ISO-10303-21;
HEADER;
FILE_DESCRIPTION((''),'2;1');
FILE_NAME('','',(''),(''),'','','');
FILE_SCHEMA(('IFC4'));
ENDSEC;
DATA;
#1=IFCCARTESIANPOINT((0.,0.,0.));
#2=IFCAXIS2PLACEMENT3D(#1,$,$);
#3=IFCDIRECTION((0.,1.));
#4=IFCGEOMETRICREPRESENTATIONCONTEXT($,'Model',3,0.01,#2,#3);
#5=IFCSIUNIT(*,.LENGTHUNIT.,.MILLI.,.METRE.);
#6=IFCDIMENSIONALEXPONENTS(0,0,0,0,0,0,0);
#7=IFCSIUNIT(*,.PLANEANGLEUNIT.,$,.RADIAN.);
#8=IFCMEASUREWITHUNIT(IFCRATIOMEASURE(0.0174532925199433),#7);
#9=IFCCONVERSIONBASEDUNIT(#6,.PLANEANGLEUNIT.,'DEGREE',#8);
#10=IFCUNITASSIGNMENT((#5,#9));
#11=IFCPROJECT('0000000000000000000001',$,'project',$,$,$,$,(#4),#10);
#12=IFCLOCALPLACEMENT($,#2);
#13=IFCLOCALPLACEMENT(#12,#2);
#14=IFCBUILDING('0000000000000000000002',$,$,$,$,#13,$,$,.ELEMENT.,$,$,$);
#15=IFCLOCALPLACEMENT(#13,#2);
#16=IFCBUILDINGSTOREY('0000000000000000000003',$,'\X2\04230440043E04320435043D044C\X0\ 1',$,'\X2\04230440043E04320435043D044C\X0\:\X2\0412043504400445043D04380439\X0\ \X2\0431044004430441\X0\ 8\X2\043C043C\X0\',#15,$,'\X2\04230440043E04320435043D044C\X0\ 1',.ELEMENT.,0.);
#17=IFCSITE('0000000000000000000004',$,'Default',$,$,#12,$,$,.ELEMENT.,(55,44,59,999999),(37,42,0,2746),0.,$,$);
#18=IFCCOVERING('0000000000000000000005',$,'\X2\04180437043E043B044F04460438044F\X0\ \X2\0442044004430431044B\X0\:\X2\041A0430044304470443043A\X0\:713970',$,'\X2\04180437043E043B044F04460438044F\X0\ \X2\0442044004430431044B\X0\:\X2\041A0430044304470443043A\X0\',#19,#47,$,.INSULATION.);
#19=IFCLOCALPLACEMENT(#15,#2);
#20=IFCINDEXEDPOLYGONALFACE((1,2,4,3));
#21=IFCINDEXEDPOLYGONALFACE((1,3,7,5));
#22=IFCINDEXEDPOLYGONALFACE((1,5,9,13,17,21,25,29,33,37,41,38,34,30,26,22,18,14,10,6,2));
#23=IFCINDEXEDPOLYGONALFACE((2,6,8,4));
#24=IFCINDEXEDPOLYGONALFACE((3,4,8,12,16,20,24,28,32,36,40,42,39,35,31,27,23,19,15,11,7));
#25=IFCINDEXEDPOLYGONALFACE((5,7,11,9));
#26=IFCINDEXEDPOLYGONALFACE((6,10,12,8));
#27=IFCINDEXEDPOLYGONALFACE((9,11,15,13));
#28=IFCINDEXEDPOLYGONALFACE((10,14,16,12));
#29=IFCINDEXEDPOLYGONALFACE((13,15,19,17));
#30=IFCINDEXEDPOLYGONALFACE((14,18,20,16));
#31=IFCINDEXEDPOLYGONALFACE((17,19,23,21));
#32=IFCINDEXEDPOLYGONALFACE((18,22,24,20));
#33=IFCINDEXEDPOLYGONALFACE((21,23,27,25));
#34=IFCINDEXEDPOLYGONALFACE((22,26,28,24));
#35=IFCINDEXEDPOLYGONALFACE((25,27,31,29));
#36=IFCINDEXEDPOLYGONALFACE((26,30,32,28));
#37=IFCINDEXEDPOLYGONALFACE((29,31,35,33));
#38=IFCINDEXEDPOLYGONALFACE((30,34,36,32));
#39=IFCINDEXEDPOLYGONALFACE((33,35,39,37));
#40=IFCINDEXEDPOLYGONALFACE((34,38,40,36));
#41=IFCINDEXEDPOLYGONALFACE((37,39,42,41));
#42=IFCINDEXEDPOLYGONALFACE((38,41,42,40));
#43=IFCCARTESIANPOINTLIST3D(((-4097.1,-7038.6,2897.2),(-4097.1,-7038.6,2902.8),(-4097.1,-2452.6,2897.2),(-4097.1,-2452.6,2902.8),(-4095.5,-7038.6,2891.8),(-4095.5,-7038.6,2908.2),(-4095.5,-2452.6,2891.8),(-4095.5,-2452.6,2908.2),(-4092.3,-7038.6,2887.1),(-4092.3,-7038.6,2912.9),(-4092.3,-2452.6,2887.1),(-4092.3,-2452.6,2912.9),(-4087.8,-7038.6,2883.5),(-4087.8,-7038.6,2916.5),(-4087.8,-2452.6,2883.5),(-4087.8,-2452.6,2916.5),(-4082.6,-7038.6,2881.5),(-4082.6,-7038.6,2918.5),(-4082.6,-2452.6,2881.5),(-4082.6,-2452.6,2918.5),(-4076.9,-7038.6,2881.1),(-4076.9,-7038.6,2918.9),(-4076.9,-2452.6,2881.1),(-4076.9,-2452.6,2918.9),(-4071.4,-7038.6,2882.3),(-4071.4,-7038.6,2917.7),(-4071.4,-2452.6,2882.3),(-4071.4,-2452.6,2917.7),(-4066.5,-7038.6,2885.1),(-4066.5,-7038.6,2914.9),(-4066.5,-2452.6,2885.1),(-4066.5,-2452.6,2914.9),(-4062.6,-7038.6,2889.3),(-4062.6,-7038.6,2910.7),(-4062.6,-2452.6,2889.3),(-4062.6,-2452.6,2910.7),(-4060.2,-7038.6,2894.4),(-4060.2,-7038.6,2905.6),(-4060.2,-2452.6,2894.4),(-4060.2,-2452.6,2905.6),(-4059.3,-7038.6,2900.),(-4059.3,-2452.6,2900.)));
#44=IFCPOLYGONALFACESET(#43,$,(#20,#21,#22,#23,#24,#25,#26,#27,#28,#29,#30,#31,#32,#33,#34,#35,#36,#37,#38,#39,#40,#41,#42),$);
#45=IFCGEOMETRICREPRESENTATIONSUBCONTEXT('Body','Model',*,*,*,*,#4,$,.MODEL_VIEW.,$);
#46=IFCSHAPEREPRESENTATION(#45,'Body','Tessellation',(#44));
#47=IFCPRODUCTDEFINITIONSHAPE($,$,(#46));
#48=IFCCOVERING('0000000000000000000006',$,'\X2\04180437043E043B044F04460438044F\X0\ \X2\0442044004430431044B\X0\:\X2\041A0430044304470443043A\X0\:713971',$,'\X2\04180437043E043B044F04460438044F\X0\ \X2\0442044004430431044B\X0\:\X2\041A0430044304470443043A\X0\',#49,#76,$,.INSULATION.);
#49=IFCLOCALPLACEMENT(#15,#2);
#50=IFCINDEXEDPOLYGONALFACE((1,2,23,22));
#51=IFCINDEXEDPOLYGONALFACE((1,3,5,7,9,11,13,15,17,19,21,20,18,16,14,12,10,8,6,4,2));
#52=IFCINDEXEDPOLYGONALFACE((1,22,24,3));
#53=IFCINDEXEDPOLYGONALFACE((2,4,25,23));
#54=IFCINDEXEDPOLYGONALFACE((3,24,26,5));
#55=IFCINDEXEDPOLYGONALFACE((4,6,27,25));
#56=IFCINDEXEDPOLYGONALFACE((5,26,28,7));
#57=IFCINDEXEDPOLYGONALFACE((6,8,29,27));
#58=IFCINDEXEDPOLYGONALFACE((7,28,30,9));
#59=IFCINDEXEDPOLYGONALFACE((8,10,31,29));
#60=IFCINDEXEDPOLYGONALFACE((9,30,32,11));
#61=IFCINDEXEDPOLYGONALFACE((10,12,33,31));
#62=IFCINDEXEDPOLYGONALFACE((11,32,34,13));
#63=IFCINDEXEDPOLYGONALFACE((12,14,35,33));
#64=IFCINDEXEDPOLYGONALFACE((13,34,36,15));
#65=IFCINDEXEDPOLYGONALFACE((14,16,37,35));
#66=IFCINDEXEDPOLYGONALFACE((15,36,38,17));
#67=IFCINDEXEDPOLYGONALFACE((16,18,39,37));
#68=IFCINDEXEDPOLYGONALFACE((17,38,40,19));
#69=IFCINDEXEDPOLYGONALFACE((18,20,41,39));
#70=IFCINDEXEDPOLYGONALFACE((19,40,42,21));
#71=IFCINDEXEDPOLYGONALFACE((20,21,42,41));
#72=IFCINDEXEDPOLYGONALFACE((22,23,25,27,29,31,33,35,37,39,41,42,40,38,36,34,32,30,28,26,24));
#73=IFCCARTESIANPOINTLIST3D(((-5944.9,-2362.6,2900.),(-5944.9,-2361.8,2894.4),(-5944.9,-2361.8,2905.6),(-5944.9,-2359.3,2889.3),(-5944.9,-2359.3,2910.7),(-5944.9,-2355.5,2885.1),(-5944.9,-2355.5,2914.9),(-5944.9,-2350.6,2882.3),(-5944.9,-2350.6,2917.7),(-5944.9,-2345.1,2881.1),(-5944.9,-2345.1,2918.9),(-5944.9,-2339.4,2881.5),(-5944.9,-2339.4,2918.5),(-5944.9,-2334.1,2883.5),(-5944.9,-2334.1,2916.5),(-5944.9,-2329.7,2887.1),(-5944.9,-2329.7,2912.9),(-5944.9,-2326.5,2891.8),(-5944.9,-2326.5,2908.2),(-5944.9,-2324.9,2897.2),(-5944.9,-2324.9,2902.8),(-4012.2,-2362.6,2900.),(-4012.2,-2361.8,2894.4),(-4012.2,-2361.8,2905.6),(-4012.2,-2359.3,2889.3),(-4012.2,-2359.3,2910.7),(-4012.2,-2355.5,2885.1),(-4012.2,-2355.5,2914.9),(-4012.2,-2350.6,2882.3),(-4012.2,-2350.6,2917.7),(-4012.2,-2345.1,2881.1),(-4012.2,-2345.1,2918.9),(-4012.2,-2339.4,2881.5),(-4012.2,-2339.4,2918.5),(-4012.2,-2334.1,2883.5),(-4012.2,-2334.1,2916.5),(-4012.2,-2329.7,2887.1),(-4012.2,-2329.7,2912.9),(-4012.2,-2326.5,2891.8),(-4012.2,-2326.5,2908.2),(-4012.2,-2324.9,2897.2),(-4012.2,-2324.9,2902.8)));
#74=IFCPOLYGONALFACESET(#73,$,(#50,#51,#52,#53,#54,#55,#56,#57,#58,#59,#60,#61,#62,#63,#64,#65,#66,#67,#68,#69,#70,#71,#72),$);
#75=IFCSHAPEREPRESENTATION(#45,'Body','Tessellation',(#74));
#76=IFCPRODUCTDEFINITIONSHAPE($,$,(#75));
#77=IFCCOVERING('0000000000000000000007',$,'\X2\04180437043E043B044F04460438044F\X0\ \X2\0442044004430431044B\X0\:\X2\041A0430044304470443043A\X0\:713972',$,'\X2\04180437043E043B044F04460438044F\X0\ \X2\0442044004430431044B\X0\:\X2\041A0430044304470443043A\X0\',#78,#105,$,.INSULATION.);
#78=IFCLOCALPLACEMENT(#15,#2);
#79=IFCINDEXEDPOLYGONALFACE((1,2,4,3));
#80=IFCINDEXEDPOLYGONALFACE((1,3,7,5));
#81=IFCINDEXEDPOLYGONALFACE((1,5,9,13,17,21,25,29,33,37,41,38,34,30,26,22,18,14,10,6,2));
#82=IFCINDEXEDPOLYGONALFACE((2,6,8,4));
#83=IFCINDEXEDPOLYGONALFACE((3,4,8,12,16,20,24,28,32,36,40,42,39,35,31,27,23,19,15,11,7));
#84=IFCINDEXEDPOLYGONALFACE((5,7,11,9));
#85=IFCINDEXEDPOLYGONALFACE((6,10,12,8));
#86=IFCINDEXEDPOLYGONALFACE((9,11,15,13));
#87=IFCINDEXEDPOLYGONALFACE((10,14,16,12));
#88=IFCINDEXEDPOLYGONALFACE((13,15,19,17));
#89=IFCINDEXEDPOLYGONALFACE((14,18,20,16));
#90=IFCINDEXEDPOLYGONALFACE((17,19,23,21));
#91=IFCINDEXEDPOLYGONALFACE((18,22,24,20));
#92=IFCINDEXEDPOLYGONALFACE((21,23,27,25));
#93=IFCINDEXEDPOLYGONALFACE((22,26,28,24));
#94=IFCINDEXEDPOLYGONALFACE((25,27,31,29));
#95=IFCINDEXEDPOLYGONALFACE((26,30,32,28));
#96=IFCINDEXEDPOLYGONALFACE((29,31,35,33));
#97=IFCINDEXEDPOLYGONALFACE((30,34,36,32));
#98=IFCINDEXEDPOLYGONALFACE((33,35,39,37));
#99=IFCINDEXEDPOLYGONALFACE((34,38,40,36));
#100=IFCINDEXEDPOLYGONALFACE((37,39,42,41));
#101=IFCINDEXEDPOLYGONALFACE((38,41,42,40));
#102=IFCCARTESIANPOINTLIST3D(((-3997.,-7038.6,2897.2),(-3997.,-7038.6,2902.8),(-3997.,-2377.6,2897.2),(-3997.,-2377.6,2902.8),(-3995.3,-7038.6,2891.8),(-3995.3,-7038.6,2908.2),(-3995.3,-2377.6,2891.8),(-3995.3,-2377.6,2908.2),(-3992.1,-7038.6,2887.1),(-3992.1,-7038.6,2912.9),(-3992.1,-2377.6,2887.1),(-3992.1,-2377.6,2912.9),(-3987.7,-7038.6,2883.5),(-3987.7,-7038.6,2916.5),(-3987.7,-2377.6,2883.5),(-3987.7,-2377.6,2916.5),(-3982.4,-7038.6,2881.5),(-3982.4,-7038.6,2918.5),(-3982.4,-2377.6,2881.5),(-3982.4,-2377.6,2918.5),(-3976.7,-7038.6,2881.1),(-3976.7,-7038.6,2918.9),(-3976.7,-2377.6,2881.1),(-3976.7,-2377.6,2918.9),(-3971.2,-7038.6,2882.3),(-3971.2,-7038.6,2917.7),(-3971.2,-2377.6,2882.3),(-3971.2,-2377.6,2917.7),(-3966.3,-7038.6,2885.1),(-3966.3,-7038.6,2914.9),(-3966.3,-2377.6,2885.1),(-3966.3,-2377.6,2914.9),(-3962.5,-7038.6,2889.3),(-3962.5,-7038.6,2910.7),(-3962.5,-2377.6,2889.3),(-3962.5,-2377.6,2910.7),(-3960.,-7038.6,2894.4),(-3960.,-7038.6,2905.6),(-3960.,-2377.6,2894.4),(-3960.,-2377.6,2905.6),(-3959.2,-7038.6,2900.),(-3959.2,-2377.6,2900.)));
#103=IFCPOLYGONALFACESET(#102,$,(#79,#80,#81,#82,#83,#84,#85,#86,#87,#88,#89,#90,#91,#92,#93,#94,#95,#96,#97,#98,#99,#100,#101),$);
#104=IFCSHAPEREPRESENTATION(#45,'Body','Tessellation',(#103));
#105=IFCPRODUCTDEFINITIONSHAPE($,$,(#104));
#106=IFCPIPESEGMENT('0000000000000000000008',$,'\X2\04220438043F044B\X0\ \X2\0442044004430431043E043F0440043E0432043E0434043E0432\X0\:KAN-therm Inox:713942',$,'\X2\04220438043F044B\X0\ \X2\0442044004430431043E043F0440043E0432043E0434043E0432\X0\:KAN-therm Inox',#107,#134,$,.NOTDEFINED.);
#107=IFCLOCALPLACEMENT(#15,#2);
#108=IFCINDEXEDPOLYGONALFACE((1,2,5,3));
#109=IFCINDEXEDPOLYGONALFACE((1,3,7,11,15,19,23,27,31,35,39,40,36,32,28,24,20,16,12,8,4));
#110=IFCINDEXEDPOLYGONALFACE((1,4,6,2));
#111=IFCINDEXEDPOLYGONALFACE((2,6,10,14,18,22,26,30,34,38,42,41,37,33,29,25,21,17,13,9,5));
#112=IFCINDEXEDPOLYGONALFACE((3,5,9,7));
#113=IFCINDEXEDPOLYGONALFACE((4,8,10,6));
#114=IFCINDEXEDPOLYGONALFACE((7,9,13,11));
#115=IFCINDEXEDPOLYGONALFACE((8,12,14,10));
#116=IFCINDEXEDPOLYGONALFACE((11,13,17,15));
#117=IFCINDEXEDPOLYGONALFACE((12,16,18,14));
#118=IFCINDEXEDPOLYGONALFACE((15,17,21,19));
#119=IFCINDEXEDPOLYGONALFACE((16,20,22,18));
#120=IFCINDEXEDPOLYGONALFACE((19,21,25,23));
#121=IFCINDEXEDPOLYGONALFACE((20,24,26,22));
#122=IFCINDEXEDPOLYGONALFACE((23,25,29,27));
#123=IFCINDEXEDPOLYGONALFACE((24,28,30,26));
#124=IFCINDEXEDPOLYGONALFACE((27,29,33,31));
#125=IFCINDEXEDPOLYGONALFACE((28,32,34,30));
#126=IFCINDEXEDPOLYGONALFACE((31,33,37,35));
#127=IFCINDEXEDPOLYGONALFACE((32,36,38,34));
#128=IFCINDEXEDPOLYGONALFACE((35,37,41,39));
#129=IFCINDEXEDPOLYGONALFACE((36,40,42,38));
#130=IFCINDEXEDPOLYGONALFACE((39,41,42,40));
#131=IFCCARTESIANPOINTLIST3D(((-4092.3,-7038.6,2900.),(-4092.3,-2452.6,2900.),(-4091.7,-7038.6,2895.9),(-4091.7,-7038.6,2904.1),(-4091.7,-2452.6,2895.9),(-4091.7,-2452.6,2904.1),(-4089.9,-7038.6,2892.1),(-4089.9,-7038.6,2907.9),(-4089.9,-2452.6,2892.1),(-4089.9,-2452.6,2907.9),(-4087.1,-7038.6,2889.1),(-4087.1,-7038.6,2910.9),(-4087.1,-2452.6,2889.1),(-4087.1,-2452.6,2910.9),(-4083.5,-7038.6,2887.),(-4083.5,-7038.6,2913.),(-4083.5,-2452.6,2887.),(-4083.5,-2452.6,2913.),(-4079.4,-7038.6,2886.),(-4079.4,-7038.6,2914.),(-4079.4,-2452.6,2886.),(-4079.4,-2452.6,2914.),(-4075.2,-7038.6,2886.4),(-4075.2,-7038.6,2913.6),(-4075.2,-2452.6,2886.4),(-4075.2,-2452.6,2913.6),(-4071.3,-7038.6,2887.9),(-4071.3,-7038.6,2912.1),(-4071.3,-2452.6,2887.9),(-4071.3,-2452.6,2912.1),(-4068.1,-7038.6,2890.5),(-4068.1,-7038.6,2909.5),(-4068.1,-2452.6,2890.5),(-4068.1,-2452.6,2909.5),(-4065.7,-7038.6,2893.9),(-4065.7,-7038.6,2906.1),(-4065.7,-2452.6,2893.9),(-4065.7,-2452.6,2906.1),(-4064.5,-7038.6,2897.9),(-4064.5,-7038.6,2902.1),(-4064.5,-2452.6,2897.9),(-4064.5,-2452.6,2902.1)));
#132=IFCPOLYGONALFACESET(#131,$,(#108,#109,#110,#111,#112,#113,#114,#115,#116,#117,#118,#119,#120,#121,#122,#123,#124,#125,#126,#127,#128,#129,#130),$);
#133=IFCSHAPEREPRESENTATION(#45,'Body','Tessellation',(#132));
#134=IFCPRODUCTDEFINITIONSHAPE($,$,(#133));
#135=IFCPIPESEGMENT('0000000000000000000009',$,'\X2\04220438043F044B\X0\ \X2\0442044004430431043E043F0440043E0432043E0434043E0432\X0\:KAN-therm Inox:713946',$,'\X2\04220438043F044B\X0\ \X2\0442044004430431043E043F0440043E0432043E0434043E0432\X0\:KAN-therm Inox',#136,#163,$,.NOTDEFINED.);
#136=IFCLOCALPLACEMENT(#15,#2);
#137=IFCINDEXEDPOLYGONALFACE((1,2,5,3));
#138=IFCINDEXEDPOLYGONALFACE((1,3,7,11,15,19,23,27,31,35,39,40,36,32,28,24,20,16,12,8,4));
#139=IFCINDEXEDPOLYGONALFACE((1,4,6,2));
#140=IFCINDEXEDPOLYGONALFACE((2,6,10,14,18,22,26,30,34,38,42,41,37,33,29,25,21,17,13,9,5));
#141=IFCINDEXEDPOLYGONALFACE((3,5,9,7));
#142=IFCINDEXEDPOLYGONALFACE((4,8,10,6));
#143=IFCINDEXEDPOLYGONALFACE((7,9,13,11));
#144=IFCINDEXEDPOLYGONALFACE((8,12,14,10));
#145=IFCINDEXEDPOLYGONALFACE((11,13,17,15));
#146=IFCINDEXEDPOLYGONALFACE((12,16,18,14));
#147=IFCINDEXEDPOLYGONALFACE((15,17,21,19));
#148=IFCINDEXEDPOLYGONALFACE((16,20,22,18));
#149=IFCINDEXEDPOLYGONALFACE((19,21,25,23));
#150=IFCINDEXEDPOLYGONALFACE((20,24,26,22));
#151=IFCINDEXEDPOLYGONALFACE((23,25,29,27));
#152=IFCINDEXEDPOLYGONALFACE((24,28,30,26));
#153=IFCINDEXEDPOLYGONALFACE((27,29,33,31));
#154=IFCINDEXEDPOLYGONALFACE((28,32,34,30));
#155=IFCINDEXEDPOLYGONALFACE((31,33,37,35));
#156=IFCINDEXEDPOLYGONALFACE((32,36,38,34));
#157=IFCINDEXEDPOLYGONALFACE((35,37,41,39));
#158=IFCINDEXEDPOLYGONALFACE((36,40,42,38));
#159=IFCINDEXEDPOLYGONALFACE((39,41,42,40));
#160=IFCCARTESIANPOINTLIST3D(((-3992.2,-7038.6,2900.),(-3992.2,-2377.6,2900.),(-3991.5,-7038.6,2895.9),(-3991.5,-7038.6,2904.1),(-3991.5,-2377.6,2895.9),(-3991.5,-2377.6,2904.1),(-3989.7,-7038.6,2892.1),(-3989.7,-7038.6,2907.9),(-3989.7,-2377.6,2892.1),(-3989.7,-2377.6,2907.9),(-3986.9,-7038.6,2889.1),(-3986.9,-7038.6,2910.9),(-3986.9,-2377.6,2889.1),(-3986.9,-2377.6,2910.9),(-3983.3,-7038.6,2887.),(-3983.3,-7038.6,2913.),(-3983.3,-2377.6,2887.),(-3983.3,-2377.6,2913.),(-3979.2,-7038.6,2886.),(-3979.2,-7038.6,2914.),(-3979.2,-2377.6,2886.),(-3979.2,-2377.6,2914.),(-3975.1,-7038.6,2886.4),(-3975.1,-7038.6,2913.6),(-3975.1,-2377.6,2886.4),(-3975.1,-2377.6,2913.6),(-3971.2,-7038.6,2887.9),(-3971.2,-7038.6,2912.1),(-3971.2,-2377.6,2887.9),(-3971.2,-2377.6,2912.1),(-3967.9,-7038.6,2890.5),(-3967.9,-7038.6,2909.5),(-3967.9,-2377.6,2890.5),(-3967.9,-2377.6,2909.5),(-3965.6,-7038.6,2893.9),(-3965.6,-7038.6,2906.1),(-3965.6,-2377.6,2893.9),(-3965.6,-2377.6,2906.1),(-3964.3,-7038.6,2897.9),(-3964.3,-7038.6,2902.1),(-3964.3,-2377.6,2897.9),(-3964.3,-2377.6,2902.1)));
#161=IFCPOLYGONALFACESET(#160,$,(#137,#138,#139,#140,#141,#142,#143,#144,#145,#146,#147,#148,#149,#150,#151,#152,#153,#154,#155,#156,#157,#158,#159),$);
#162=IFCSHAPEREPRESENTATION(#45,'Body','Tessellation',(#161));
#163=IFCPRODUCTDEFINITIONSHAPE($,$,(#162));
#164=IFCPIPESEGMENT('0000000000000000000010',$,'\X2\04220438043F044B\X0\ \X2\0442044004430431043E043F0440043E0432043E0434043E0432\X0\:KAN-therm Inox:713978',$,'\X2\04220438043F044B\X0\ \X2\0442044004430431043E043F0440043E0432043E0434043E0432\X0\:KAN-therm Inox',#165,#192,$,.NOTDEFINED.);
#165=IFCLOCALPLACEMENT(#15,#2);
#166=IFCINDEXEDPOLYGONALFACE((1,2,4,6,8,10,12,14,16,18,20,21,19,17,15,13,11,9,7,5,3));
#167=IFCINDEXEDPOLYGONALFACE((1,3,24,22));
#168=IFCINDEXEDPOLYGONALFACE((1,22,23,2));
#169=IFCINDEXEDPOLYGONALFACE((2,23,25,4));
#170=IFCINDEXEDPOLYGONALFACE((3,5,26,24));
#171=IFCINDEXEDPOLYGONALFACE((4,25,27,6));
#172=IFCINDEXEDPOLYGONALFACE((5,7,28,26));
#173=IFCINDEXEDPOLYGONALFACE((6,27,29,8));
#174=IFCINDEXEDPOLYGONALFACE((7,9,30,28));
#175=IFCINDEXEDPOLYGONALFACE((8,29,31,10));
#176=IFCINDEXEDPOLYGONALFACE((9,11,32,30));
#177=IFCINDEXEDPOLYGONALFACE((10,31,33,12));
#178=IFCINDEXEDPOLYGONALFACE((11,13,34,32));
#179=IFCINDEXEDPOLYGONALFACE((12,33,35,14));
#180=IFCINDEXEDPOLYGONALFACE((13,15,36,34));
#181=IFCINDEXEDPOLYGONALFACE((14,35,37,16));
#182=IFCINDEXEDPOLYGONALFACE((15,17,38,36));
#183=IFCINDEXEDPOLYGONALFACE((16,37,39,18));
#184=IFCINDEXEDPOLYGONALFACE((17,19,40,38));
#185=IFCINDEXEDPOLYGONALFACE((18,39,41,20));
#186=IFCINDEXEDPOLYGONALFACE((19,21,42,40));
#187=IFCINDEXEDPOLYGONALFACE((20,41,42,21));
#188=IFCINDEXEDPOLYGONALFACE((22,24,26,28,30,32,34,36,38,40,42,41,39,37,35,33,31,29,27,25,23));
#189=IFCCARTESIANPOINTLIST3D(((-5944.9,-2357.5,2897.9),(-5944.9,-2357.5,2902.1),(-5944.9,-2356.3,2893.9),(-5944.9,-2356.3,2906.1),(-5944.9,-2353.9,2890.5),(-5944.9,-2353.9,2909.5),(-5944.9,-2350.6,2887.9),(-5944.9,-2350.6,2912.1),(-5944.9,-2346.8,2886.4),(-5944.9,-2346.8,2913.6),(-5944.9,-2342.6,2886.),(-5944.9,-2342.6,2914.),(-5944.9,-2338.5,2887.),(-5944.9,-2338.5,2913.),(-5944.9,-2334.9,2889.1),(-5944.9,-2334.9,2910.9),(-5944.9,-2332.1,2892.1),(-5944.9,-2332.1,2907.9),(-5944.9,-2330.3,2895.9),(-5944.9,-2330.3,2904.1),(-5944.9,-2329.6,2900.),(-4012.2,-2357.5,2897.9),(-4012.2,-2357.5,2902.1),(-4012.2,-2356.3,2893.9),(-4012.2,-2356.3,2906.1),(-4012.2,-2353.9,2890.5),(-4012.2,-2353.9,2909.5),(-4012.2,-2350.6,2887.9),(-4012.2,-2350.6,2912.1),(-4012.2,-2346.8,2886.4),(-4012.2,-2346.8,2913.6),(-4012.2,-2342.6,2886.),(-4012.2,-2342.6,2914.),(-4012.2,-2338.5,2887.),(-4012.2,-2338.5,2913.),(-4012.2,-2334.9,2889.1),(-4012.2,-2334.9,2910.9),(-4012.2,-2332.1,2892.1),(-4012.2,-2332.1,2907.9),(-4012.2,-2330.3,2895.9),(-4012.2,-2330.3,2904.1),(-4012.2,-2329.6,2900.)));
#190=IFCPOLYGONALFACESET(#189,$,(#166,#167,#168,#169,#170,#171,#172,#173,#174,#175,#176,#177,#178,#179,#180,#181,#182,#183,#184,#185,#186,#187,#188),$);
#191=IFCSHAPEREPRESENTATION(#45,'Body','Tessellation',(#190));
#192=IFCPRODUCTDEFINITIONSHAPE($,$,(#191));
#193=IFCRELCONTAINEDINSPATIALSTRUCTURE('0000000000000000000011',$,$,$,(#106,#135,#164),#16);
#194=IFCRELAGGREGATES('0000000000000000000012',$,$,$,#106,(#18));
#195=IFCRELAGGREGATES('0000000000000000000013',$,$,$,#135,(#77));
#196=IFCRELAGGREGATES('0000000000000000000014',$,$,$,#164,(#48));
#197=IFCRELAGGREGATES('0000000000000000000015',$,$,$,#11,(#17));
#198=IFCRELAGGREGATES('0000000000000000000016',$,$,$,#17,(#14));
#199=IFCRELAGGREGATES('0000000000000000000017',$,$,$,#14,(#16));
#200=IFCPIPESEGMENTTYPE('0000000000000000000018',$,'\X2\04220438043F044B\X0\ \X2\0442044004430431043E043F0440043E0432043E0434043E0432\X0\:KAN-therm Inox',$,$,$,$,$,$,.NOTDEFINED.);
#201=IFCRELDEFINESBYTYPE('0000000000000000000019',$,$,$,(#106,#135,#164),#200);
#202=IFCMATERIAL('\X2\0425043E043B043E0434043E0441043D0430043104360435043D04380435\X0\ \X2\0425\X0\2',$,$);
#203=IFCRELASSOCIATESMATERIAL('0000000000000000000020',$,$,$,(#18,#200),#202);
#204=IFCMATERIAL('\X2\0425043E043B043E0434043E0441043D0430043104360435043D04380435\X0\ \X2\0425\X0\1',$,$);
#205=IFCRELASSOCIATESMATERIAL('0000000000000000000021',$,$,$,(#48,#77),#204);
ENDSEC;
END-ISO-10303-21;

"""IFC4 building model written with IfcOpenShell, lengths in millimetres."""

from ifc_helpers import new_model, entity, si_unit, converted_unit, direction, frame, frame_2d, origin, origin_2d_with_axis, place, context, subcontext, project, spatial, circle, extrude, material, type_object, element, aggregate, save


model = new_model("IFC4")

# Units and contexts
model_context = context("Model", 3, precision=0.01, world=origin(), true_north=direction((0.0, 1.0)))
body_context = subcontext(model_context, "Body", "Model", "MODEL_VIEW")
ifc_project = project(units=[si_unit("LENGTHUNIT", "METRE", prefix="MILLI"), converted_unit("PLANEANGLEUNIT", "DEGREE", entity("IfcRatioMeasure", 0.0174532925199433), si_unit("PLANEANGLEUNIT", "RADIAN"), dimensions=[0, 0, 0, 0, 0, 0, 0])], contexts=[model_context])

# Site, building, storey
site_placement = place(None, origin())
site = spatial("IfcSite", under=ifc_project, at=site_placement, Name="Default", CompositionType="ELEMENT", RefLatitude=(55, 44, 59, 999999), RefLongitude=(37, 42, 0, 2746), RefElevation=0.0)
building_placement = place(site_placement, origin())
building = spatial("IfcBuilding", under=site, at=building_placement, CompositionType="ELEMENT")
storey_placement = place(building_placement, origin())
storey = spatial("IfcBuildingStorey", under=building, at=storey_placement, Name="Уровень 1", ObjectType="Уровень:Верхний брус 8мм", LongName="Уровень 1", CompositionType="ELEMENT", Elevation=0.0)

# Coverings
ifc_material_1 = material(Name="Холодоснабжение Х2")
covering_1_placement = place(storey_placement, frame((-4098.9, -7038.6, 2879.4)))
covering_1 = element("IfcCovering", 1, at=covering_1_placement, material=ifc_material_1, Name="Изоляция трубы:Каучук:713970", ObjectType="Изоляция трубы:Каучук", PredefinedType="INSULATION", context=body_context, shape_type="SweptSolid", body=[
    extrude(circle(Radius=19.0, at=origin_2d_with_axis()), frame((20.6, 0.0, 20.6), z_axis=(0.0, 1.0, 0.0), x_axis=(1.0, 0.0, 0.0)), (0.0, 0.0, 1.0), 4586.0),
])
ifc_material_2 = material(Name="Холодоснабжение Х1")
covering_2_placement = place(storey_placement, frame((-5944.9, -2364.2, 2879.4)))
covering_2 = element("IfcCovering", 2, at=covering_2_placement, material=ifc_material_2, Name="Изоляция трубы:Каучук:713971", ObjectType="Изоляция трубы:Каучук", PredefinedType="INSULATION", context=body_context, shape_type="SweptSolid", body=[
    extrude(circle(Radius=19.0, at=frame_2d((0.0, 0.0), x_axis=(1.0, 0.0))), frame((0.0, 20.6, 20.6), z_axis=(1.0, 0.0, 0.0), x_axis=(0.0, -1.0, 0.0)), (0.0, 0.0, 1.0), 1932.8),
])
covering_3_placement = place(storey_placement, frame((-3998.8, -7038.6, 2879.4)))
covering_3 = element("IfcCovering", 3, at=covering_3_placement, material=ifc_material_2, Name="Изоляция трубы:Каучук:713972", ObjectType="Изоляция трубы:Каучук", PredefinedType="INSULATION", context=body_context, shape_type="SweptSolid", body=[
    extrude(circle(Radius=19.0, at=origin_2d_with_axis()), frame((20.6, 0.0, 20.6), z_axis=(0.0, 1.0, 0.0), x_axis=(1.0, 0.0, 0.0)), (0.0, 0.0, 1.0), 4661.0),
])

# Pipe segments
pipe_segment_type_1 = type_object("IfcPipeSegmentType", Name="Типы трубопроводов:KAN-therm Inox", PredefinedType="NOTDEFINED", material=ifc_material_1)
pipe_segment_1_placement = place(storey_placement, frame((-4093.9, -7038.6, 2884.4)))
pipe_segment_1 = element("IfcPipeSegment", 4, at=pipe_segment_1_placement, inside=storey, type_object=pipe_segment_type_1, Name="Типы трубопроводов:KAN-therm Inox:713942", ObjectType="Типы трубопроводов:KAN-therm Inox", PredefinedType="NOTDEFINED", context=body_context, shape_type="SweptSolid", body=[
    extrude(circle(Radius=14.0, at=origin_2d_with_axis()), frame((15.6, 0.0, 15.6), z_axis=(0.0, 1.0, 0.0), x_axis=(-1.0, 0.0, 0.0)), (0.0, 0.0, 1.0), 4586.0),
])
aggregate(pipe_segment_1, [covering_1])
pipe_segment_2_placement = place(storey_placement, frame((-3993.8, -7038.6, 2884.4)))
pipe_segment_2 = element("IfcPipeSegment", 5, at=pipe_segment_2_placement, inside=storey, type_object=pipe_segment_type_1, Name="Типы трубопроводов:KAN-therm Inox:713946", ObjectType="Типы трубопроводов:KAN-therm Inox", PredefinedType="NOTDEFINED", context=body_context, shape_type="SweptSolid", body=[
    extrude(circle(Radius=14.0, at=origin_2d_with_axis()), frame((15.6, 0.0, 15.6), z_axis=(0.0, 1.0, 0.0), x_axis=(-1.0, 0.0, 0.0)), (0.0, 0.0, 1.0), 4661.0),
])
aggregate(pipe_segment_2, [covering_3])
pipe_segment_3_placement = place(storey_placement, frame((-5944.9, -2359.2, 2884.4)))
pipe_segment_3 = element("IfcPipeSegment", 6, at=pipe_segment_3_placement, inside=storey, type_object=pipe_segment_type_1, Name="Типы трубопроводов:KAN-therm Inox:713978", ObjectType="Типы трубопроводов:KAN-therm Inox", PredefinedType="NOTDEFINED", context=body_context, shape_type="SweptSolid", body=[
    extrude(circle(Radius=14.0, at=frame_2d((0.0, 0.0), x_axis=(1.0, 0.0))), frame((0.0, 15.6, 15.6), z_axis=(1.0, 0.0, 0.0), x_axis=(0.0, 1.0, 0.0)), (0.0, 0.0, 1.0), 1932.8),
])
aggregate(pipe_segment_3, [covering_2])

save(model, "model.ifc")
